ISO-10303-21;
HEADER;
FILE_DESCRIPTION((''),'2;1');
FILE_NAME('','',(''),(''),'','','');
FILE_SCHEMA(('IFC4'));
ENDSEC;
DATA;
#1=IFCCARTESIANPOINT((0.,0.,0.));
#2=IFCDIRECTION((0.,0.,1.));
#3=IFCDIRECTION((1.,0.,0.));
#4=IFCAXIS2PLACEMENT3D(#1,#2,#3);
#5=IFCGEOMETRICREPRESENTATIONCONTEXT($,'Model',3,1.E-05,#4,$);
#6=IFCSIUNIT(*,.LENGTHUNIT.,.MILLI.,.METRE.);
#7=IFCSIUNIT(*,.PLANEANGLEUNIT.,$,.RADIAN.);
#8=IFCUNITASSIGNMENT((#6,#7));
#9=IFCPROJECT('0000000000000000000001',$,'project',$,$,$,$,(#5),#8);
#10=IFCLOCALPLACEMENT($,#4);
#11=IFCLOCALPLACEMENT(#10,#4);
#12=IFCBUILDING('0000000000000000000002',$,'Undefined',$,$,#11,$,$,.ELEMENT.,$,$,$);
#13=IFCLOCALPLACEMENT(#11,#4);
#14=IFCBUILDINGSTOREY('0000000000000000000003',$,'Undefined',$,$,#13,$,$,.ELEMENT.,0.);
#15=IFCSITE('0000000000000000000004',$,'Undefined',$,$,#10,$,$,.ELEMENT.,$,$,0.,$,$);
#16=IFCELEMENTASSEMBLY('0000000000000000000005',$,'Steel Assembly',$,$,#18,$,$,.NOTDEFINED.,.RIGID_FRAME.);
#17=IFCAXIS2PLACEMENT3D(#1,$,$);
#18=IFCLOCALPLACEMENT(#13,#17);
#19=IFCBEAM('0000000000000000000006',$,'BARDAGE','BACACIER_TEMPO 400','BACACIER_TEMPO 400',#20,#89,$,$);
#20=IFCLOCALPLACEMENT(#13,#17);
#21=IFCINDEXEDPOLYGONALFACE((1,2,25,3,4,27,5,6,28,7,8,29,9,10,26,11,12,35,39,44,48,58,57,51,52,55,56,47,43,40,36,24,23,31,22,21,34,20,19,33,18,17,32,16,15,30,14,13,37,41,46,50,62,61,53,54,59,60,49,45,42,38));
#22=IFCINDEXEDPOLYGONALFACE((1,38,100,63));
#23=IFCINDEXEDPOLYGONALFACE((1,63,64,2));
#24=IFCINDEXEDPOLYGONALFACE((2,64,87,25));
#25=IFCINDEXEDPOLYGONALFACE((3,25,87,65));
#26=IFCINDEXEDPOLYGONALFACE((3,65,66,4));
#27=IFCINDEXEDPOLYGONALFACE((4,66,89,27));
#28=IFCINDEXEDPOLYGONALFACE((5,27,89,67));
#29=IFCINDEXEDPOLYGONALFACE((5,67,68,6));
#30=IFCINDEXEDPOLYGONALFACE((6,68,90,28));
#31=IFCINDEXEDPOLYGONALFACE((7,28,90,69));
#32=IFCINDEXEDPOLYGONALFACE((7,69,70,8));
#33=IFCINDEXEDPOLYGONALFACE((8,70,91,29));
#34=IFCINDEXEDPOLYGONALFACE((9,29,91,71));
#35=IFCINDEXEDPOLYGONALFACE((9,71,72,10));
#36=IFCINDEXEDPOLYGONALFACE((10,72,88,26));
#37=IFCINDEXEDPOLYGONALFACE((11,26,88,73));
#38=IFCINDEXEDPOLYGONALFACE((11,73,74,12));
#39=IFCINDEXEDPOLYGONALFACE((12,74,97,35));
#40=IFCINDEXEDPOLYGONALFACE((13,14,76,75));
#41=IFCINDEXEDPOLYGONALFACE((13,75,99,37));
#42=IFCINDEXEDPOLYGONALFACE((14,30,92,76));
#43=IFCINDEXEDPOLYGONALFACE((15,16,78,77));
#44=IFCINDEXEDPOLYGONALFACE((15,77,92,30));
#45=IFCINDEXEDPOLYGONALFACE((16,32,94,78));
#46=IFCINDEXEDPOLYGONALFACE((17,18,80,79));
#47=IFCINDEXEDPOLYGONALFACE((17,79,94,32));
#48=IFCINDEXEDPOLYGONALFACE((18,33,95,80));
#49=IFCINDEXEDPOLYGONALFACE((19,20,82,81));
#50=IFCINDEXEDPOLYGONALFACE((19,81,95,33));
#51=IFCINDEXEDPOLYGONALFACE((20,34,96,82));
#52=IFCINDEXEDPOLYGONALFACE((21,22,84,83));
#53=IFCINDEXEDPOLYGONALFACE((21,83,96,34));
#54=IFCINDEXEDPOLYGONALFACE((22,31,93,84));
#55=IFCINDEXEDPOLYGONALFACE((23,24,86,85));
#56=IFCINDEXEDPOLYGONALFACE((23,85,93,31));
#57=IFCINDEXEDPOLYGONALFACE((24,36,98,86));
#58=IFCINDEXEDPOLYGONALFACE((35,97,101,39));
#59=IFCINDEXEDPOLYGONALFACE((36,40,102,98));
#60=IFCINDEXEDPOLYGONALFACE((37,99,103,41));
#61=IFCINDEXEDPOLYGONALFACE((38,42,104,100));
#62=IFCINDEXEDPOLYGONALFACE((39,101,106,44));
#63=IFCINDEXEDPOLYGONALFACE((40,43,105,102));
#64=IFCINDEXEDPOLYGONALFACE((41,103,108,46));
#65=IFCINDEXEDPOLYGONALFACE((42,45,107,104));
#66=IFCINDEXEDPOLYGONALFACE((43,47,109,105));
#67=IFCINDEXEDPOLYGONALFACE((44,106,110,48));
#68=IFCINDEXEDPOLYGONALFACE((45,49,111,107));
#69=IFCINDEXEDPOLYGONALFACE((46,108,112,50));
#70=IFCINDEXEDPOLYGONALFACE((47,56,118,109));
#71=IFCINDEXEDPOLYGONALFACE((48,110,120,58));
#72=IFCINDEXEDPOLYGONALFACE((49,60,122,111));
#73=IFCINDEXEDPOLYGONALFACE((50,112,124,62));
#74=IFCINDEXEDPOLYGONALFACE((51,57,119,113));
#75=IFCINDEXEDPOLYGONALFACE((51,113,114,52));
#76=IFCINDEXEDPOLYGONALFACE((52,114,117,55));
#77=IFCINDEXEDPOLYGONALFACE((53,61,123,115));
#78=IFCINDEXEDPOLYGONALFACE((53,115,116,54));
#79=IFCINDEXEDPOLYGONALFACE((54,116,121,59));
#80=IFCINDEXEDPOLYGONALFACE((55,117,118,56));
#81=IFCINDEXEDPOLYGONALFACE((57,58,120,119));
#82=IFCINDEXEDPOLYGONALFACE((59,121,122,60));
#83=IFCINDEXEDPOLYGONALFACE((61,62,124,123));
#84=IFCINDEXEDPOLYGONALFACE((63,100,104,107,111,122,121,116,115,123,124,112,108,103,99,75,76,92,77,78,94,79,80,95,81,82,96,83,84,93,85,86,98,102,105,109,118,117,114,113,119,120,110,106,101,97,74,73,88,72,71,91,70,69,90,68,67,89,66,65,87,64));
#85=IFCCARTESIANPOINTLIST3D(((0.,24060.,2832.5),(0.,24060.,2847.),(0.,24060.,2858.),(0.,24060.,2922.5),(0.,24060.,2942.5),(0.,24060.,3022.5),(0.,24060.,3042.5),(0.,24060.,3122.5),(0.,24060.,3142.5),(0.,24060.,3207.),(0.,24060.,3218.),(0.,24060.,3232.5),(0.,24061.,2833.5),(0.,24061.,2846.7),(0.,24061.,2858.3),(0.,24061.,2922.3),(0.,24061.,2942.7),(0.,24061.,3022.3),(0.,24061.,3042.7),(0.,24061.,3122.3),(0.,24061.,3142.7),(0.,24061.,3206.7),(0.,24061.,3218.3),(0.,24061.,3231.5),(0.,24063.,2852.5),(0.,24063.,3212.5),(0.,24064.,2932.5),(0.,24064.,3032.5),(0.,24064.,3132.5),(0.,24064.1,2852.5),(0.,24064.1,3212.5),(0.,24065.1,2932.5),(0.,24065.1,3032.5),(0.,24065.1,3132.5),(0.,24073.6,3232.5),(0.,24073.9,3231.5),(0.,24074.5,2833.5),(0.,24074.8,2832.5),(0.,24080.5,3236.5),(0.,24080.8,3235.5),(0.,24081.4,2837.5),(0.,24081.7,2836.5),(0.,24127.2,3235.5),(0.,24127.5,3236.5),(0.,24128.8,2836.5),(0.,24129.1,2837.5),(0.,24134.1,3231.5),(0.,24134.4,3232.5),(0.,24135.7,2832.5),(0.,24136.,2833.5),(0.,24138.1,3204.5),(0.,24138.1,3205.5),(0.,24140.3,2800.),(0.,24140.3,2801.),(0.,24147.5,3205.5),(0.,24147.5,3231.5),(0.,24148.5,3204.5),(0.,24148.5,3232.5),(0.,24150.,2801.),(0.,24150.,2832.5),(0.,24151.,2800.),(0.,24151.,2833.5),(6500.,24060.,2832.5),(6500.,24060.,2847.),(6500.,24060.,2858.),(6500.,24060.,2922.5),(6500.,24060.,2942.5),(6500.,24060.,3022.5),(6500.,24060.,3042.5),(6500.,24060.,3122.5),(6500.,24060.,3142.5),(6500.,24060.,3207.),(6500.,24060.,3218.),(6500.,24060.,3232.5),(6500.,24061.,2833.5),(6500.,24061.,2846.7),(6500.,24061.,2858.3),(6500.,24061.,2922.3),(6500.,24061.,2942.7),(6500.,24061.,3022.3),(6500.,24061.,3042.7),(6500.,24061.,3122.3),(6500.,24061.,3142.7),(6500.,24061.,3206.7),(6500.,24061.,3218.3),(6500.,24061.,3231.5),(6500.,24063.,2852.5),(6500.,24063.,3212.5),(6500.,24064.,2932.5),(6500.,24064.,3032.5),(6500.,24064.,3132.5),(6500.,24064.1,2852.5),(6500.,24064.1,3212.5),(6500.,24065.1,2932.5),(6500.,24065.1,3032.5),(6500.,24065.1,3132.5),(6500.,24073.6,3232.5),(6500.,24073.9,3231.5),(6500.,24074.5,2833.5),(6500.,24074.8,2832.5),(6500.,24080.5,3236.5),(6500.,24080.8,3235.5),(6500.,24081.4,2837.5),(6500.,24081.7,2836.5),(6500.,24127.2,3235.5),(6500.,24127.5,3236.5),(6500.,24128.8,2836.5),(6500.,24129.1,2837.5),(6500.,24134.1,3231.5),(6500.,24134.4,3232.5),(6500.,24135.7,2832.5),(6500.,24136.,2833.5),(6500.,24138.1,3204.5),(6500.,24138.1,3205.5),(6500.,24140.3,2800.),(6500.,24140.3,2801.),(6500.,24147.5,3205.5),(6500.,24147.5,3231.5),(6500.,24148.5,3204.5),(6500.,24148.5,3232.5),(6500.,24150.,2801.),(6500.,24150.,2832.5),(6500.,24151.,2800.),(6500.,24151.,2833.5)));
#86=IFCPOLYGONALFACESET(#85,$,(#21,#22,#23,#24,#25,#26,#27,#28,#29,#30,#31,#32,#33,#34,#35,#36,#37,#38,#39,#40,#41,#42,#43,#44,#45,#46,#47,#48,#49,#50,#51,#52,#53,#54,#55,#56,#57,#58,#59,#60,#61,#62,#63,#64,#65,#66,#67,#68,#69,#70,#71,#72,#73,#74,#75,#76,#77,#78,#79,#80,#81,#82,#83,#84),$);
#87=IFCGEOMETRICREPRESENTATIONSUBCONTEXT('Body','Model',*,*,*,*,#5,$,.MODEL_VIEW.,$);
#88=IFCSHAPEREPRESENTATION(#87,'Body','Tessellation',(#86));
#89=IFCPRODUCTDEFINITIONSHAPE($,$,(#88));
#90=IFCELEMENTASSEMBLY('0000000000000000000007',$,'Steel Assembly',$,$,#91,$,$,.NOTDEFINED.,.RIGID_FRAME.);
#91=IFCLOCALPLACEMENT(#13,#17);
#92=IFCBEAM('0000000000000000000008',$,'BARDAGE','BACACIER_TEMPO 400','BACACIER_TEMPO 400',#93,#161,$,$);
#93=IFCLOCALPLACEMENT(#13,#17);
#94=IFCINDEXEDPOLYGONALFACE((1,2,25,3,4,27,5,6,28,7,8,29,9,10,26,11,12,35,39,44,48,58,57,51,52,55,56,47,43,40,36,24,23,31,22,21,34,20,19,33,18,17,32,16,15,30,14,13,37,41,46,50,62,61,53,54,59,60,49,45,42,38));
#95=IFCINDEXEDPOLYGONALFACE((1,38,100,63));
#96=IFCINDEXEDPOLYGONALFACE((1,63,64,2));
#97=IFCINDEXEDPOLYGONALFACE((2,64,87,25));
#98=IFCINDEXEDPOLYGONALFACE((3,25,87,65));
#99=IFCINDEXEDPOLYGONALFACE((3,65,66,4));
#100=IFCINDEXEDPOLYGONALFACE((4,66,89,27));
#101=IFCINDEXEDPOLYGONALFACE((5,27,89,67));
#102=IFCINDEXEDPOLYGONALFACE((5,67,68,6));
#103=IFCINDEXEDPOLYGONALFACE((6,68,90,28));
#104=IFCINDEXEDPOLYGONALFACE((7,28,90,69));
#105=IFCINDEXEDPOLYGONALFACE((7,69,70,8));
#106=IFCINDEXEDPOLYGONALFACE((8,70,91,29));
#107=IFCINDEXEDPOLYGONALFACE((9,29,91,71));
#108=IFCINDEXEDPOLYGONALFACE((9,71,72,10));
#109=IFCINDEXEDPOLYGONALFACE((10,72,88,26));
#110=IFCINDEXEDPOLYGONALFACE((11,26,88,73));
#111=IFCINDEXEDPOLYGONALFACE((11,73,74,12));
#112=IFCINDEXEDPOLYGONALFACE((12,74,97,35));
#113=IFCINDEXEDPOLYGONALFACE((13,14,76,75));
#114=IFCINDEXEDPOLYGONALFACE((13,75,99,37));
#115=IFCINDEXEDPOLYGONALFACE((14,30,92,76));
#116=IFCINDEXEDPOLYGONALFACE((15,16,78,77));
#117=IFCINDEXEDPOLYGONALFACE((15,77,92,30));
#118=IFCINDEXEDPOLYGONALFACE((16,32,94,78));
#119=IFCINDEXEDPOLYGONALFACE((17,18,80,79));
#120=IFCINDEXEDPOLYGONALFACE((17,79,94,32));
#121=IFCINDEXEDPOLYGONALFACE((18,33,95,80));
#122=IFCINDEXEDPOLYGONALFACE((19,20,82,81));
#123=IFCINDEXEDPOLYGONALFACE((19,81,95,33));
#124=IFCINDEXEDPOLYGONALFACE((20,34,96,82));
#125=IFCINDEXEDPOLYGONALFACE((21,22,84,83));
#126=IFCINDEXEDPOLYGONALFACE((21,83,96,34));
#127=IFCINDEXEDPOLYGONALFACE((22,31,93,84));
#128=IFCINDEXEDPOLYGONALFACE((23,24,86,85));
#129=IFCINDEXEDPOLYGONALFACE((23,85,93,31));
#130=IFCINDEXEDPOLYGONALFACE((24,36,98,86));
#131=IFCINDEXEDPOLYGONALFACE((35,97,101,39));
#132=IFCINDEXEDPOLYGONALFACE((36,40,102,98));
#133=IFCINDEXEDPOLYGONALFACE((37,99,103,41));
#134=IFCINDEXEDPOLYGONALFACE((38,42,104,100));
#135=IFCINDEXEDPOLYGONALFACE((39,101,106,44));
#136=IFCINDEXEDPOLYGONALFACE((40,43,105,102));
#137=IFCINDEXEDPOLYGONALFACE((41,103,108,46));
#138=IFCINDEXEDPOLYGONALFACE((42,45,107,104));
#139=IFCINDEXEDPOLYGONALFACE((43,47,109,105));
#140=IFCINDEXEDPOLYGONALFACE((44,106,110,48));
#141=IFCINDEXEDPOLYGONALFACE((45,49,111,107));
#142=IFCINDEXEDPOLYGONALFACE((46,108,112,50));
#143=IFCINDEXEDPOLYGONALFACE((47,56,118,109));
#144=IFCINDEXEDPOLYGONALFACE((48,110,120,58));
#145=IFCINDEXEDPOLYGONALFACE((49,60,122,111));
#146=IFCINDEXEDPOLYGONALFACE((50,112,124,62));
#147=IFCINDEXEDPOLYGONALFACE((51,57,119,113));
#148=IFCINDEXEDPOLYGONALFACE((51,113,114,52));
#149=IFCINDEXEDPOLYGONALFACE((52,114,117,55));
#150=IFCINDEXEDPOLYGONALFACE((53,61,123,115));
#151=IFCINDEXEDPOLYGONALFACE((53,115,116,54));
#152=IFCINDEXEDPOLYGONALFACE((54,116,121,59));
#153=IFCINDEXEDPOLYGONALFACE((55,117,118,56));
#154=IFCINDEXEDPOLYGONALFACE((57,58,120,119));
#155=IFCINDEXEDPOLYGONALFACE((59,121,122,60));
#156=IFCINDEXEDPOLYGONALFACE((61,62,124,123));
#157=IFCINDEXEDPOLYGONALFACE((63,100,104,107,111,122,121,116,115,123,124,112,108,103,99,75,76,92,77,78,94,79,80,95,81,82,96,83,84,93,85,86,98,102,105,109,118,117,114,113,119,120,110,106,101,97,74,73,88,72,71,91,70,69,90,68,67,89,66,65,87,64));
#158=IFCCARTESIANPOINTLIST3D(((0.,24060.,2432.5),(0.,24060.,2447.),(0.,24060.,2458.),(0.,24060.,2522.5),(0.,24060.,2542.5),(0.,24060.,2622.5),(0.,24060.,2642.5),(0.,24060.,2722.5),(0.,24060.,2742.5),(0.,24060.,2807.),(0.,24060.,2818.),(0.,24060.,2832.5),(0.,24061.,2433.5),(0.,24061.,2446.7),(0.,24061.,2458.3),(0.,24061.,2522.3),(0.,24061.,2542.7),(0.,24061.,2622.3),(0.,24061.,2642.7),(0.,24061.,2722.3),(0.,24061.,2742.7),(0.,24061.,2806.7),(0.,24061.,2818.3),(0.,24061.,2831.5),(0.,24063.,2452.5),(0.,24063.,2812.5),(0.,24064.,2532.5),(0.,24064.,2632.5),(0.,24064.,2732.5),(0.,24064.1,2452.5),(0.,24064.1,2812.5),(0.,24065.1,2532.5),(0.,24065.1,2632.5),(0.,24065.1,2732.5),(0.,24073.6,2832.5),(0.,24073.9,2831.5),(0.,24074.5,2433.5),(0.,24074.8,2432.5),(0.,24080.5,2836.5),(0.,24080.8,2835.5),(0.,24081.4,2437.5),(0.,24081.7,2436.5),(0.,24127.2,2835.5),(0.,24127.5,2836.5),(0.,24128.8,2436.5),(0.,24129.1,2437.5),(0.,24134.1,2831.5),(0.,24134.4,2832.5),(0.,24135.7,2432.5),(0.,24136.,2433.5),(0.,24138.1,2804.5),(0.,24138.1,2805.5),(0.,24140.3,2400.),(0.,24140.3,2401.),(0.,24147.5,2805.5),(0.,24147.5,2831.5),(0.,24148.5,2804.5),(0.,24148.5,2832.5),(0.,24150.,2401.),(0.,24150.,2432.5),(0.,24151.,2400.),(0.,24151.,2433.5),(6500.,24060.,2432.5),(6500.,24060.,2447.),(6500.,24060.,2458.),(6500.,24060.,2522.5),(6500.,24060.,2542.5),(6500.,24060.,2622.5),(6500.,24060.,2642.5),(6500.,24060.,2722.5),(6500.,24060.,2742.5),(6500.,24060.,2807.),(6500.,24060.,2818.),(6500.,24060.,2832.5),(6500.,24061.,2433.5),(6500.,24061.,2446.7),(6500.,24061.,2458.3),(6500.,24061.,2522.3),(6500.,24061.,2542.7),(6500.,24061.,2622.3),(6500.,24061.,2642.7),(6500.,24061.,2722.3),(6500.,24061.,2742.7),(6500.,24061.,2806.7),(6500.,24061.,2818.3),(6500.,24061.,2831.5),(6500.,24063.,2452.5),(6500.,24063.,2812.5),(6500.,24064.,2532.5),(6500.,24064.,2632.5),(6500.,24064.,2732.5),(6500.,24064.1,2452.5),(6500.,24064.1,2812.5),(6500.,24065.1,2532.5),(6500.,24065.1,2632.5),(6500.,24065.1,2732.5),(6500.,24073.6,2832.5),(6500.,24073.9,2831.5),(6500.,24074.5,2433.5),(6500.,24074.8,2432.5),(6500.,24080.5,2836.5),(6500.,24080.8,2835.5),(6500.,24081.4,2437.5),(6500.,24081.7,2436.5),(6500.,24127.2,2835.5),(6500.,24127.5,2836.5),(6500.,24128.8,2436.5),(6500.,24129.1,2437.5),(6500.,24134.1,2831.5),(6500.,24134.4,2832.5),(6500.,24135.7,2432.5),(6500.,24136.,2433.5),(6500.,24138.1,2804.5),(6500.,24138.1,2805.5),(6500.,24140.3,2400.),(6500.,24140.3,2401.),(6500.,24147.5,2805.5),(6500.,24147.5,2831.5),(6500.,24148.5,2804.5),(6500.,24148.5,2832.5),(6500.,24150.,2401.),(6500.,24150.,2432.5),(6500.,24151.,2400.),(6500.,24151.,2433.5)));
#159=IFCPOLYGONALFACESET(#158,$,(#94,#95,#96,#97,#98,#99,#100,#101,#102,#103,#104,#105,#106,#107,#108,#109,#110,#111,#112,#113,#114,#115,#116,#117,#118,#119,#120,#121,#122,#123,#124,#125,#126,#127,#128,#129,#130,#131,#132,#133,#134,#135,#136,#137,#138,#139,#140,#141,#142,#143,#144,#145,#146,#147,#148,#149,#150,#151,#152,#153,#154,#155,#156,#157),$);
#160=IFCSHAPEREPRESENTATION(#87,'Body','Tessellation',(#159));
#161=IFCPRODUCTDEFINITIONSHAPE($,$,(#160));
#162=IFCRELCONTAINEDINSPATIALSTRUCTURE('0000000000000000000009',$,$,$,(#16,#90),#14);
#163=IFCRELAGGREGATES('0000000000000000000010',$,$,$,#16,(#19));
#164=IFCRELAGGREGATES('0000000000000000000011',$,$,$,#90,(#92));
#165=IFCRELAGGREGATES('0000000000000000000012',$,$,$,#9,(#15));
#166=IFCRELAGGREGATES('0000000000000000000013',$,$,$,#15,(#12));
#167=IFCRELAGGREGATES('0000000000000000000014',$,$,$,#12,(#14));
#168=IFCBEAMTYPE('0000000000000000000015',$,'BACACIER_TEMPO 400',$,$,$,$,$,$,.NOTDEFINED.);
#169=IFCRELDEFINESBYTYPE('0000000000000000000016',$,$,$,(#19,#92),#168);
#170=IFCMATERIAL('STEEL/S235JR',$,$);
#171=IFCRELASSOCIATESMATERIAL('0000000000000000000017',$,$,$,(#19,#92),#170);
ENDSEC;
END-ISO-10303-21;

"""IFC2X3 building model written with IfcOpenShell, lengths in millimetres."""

from ifc_helpers import new_model, si_unit, frame, origin_with_axes, place, context, subcontext, project, spatial, polyline, outline, extrude, material, type_object, element, aggregate, save


model = new_model("IFC2X3")

# Units and contexts
model_context = context("Model", 3, precision=1e-05, world=origin_with_axes())
body_context = subcontext(model_context, "Body", "Model", "MODEL_VIEW")
ifc_project = project(units=[si_unit("LENGTHUNIT", "METRE", prefix="MILLI"), si_unit("PLANEANGLEUNIT", "RADIAN")], contexts=[model_context])

# Site, building, storey
site_placement = place(None, origin_with_axes())
site = spatial("IfcSite", under=ifc_project, at=site_placement, Name="Undefined", CompositionType="ELEMENT", RefElevation=0.0)
building_placement = place(site_placement, origin_with_axes())
building = spatial("IfcBuilding", under=site, at=building_placement, Name="Undefined", CompositionType="ELEMENT")
storey_placement = place(building_placement, origin_with_axes())
storey = spatial("IfcBuildingStorey", under=building, at=storey_placement, Name="Undefined", CompositionType="ELEMENT", Elevation=0.0)

# Element assemblies, beams
ifc_material_1 = material(Name="STEEL/S235JR")
beam_type_1 = type_object("IfcBeamType", Name="BACACIER_TEMPO 400", PredefinedType="NOTDEFINED")
assembly_1_placement = place(storey_placement, origin_with_axes())
assembly_1 = element("IfcElementAssembly", 1, at=assembly_1_placement, inside=storey, Name="Steel Assembly", AssemblyPlace="NOTDEFINED", PredefinedType="RIGID_FRAME")
beam_1_placement = place(assembly_1_placement, frame((0.0, 24105.5, 3018.2), z_axis=(0.0, 1.0, 0.0), x_axis=(1.0, 0.0, 0.0)))
beam_1 = element("IfcBeam", 2, at=beam_1_placement, type_object=beam_type_1, material=ifc_material_1, Name="BARDAGE", Description="BACACIER_TEMPO 400", ObjectType="BACACIER_TEMPO 400", context=body_context, shape_type="SweptSolid", body=[
    extrude(outline(polyline([(218.2, -25.0), (214.2, -31.9), (214.2, -45.5), (199.8, -45.5), (194.2, -42.5), (188.8, -45.5), (124.2, -45.5), (114.2, -41.5), (104.2, -45.5), (24.2, -45.5), (14.2, -41.5), (4.2, -45.5), (-75.8, -45.5), (-85.8, -41.5), (-95.8, -45.5), (-160.2, -45.5), (-165.8, -42.5), (-171.2, -45.5), (-185.8, -45.5), (-185.8, -30.7), (-181.8, -23.8), (-181.8, 23.3), (-185.8, 30.2), (-185.8, 44.5), (-217.2, 44.5), (-217.2, 34.8), (-218.2, 34.8), (-218.2, 45.5), (-184.8, 45.5), (-184.8, 30.5), (-180.8, 23.6), (-180.8, -24.1), (-184.8, -31.0), (-184.8, -44.5), (-171.5, -44.5), (-165.8, -41.4), (-160.0, -44.5), (-95.9, -44.5), (-85.8, -40.4), (-75.6, -44.5), (4.1, -44.5), (14.2, -40.4), (24.4, -44.5), (104.1, -44.5), (114.2, -40.4), (124.4, -44.5), (188.5, -44.5), (194.2, -41.4), (200.0, -44.5), (213.2, -44.5), (213.2, -31.6), (217.2, -24.7), (217.2, 21.7), (213.2, 28.6), (213.2, 42.0), (187.2, 42.0), (187.2, 32.5), (186.2, 32.5), (186.2, 43.0), (214.2, 43.0), (214.2, 28.9), (218.2, 22.0), (218.2, -25.0)])), frame((6500.0, 0.0, 0.0), z_axis=(-1.0, 0.0, 0.0), x_axis=(0.0, -1.0, 0.0)), (0.0, 0.0, 1.0), 6500.0),
])
aggregate(assembly_1, [beam_1])
assembly_2_placement = place(storey_placement, origin_with_axes())
assembly_2 = element("IfcElementAssembly", 3, at=assembly_2_placement, inside=storey, Name="Steel Assembly", AssemblyPlace="NOTDEFINED", PredefinedType="RIGID_FRAME")
beam_2_placement = place(assembly_2_placement, frame((0.0, 24105.5, 2618.2), z_axis=(0.0, 1.0, 0.0), x_axis=(1.0, 0.0, 0.0)))
beam_2 = element("IfcBeam", 4, at=beam_2_placement, type_object=beam_type_1, material=ifc_material_1, Name="BARDAGE", Description="BACACIER_TEMPO 400", ObjectType="BACACIER_TEMPO 400", context=body_context, shape_type="SweptSolid", body=[
    extrude(outline(polyline([(218.2, -25.0), (214.2, -31.9), (214.2, -45.5), (199.8, -45.5), (194.2, -42.5), (188.8, -45.5), (124.2, -45.5), (114.2, -41.5), (104.2, -45.5), (24.2, -45.5), (14.2, -41.5), (4.2, -45.5), (-75.8, -45.5), (-85.8, -41.5), (-95.8, -45.5), (-160.2, -45.5), (-165.8, -42.5), (-171.2, -45.5), (-185.8, -45.5), (-185.8, -30.7), (-181.8, -23.8), (-181.8, 23.3), (-185.8, 30.2), (-185.8, 44.5), (-217.2, 44.5), (-217.2, 34.8), (-218.2, 34.8), (-218.2, 45.5), (-184.8, 45.5), (-184.8, 30.5), (-180.8, 23.6), (-180.8, -24.1), (-184.8, -31.0), (-184.8, -44.5), (-171.5, -44.5), (-165.8, -41.4), (-160.0, -44.5), (-95.9, -44.5), (-85.8, -40.4), (-75.6, -44.5), (4.1, -44.5), (14.2, -40.4), (24.4, -44.5), (104.1, -44.5), (114.2, -40.4), (124.4, -44.5), (188.5, -44.5), (194.2, -41.4), (200.0, -44.5), (213.2, -44.5), (213.2, -31.6), (217.2, -24.7), (217.2, 21.7), (213.2, 28.6), (213.2, 42.0), (187.2, 42.0), (187.2, 32.5), (186.2, 32.5), (186.2, 43.0), (214.2, 43.0), (214.2, 28.9), (218.2, 22.0), (218.2, -25.0)])), frame((6500.0, 0.0, 0.0), z_axis=(-1.0, 0.0, 0.0), x_axis=(0.0, -1.0, 0.0)), (0.0, 0.0, 1.0), 6500.0),
])
aggregate(assembly_2, [beam_2])

save(model, "model.ifc")
